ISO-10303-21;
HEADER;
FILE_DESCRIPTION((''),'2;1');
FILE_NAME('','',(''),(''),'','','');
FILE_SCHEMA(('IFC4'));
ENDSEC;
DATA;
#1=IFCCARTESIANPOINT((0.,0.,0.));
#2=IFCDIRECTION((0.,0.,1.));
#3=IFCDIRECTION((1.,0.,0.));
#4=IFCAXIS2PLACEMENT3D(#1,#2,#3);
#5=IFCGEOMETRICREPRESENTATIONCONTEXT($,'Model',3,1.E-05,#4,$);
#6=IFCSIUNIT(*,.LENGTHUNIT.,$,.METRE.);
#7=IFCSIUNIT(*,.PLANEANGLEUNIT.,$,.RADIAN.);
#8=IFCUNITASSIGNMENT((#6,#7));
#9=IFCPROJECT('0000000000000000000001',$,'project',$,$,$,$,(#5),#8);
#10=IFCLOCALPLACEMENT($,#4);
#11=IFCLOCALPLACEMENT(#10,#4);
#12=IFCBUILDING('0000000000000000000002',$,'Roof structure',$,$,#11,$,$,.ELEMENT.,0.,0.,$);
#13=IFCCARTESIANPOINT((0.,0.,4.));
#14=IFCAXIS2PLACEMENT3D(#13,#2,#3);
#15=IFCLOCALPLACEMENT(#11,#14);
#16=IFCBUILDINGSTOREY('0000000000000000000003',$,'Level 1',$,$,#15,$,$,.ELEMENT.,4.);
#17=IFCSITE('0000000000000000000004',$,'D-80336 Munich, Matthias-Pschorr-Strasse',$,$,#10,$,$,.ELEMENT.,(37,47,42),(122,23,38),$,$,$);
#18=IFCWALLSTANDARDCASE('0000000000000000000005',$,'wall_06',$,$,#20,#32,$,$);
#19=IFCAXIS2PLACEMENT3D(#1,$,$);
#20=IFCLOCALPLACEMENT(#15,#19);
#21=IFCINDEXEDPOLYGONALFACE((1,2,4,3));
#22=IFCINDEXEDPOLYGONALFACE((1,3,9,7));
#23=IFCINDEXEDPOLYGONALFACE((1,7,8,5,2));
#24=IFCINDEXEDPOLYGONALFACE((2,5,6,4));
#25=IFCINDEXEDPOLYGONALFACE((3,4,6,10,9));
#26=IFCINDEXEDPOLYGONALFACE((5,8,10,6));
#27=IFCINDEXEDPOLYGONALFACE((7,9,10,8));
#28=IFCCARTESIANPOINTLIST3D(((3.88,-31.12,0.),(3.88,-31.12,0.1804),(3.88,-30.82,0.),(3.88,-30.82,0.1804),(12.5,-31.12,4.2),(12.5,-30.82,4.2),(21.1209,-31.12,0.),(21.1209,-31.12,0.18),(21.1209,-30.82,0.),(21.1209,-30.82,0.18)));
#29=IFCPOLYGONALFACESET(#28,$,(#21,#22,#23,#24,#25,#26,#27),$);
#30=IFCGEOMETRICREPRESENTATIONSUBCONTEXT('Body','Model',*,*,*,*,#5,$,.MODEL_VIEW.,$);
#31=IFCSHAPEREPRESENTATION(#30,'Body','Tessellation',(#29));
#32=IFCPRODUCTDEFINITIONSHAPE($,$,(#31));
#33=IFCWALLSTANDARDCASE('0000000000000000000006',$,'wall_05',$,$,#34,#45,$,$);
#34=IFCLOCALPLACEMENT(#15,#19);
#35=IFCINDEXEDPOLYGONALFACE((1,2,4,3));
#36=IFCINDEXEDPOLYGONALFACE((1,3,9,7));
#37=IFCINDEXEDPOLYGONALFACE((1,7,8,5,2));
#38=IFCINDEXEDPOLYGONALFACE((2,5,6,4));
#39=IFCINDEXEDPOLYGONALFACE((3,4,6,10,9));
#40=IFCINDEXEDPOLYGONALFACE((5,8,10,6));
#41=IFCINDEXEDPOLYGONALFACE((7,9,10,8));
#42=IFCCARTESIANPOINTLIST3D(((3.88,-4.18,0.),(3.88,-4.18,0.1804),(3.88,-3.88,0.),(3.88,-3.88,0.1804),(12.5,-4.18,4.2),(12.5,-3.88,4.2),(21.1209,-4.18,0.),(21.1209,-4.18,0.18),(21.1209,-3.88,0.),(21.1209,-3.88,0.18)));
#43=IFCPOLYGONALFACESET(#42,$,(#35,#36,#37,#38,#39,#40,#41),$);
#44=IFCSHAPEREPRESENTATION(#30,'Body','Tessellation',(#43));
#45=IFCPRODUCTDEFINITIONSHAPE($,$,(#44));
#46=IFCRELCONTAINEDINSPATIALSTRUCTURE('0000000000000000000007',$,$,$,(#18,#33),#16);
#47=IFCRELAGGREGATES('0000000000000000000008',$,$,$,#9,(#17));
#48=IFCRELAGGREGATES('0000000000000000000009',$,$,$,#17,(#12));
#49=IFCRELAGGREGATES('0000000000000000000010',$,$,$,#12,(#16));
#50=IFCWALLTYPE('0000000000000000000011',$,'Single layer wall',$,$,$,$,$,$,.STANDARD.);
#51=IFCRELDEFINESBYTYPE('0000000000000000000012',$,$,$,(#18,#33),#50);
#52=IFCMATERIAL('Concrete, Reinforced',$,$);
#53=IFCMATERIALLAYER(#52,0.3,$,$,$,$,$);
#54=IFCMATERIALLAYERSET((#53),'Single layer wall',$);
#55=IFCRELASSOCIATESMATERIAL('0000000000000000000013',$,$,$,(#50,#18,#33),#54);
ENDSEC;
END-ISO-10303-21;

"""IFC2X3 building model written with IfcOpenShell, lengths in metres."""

from ifc_helpers import new_model, si_unit, frame, origin_with_axes, place, context, subcontext, project, spatial, polyline, outline, extrude, clip, bounded_halfspace, material, layer, layer_set, layer_usage, type_object, element, save


model = new_model("IFC2X3")

# Units and contexts
model_context = context("Model", 3, precision=1e-05, world=origin_with_axes())
body_context = subcontext(model_context, "Body", "Model", "MODEL_VIEW")
ifc_project = project(units=[si_unit("LENGTHUNIT", "METRE"), si_unit("PLANEANGLEUNIT", "RADIAN")], contexts=[model_context])

# Site, building, storey
site_placement = place(None, origin_with_axes())
site = spatial("IfcSite", under=ifc_project, at=site_placement, Name="D-80336 Munich, Matthias-Pschorr-Strasse", CompositionType="ELEMENT", RefLatitude=(37, 47, 42), RefLongitude=(122, 23, 38))
building_placement = place(site_placement, origin_with_axes())
building = spatial("IfcBuilding", under=site, at=building_placement, Name="Roof structure", CompositionType="ELEMENT", ElevationOfRefHeight=0.0, ElevationOfTerrain=0.0)
storey_placement = place(building_placement, frame((0.0, 0.0, 4.0), z_axis=(0.0, 0.0, 1.0), x_axis=(1.0, 0.0, 0.0)))
storey = spatial("IfcBuildingStorey", under=building, at=storey_placement, Name="Level 1", CompositionType="ELEMENT", Elevation=4.0)

# Walls
ifc_material = material(Name="Concrete, Reinforced")
ifc_layer = layer(ifc_material, 0.3)
ifc_layer_set = layer_set([ifc_layer], Name="Single layer wall")
ifc_layer_usage_1 = layer_usage(ifc_layer_set, "AXIS2", "POSITIVE", 0.0)
wall_type = type_object("IfcWallType", Name="Single layer wall", PredefinedType="STANDARD", material=ifc_layer_set)
wall_1_placement = place(storey_placement, frame((3.88, -31.12, 0.0), z_axis=(0.0, 0.0, 1.0), x_axis=(1.0, 0.0, 0.0)))
element("IfcWallStandardCase", 1, at=wall_1_placement, inside=storey, type_object=wall_type, material=ifc_layer_usage_1, Name="wall_06", context=body_context, shape_type="Clipping", body=[
    clip(clip(extrude(outline(polyline([(-8.6205, 0.15), (8.6205, 0.15), (8.6205, -0.15), (-8.6205, -0.15), (-8.6205, 0.15)])), frame((8.6205, 0.15, 0.0), z_axis=(0.0, 0.0, 1.0), x_axis=(1.0, 0.0, 0.0)), (0.0, 0.0, 1.0), 4.2), bounded_halfspace(frame((-4.7882, 31.12, -2.0523), z_axis=(-0.422618, 0.0, 0.906308), x_axis=(0.0, -1.0, 0.0)), False, frame((8.6205, 0.15, 0.0), z_axis=(0.0, 0.0, 1.0), x_axis=(1.0, 0.0, 0.0)), polyline([(-0.0005, 0.15), (-8.6205, 0.15), (-8.6205, -0.15), (-0.0005, -0.15), (-0.0005, 0.15)]))), bounded_halfspace(frame((1.4934, 31.12, 7.5232), z_axis=(0.422618, 0.0, 0.906308), x_axis=(0.0, 1.0, 0.0)), False, frame((8.6205, 0.15, 0.0), z_axis=(0.0, 0.0, 1.0), x_axis=(1.0, 0.0, 0.0)), polyline([(8.6205, 0.15), (-0.0005, 0.15), (-0.0005, -0.15), (8.6205, -0.15), (8.6205, 0.15)]))),
])
ifc_layer_usage_2 = layer_usage(ifc_layer_set, "AXIS2", "POSITIVE", 0.0)
wall_2_placement = place(storey_placement, frame((3.88, -4.18, 0.0), z_axis=(0.0, 0.0, 1.0), x_axis=(1.0, 0.0, 0.0)))
element("IfcWallStandardCase", 2, at=wall_2_placement, inside=storey, type_object=wall_type, material=ifc_layer_usage_2, Name="wall_05", context=body_context, shape_type="Clipping", body=[
    clip(clip(extrude(outline(polyline([(-8.6205, 0.15), (8.6205, 0.15), (8.6205, -0.15), (-8.6205, -0.15), (-8.6205, 0.15)])), frame((8.6205, 0.15, 0.0), z_axis=(0.0, 0.0, 1.0), x_axis=(1.0, 0.0, 0.0)), (0.0, 0.0, 1.0), 4.2), bounded_halfspace(frame((-4.7882, 4.18, -2.0523), z_axis=(-0.422618, 0.0, 0.906308), x_axis=(0.0, -1.0, 0.0)), False, frame((8.6205, 0.15, 0.0), z_axis=(0.0, 0.0, 1.0), x_axis=(1.0, 0.0, 0.0)), polyline([(-0.0005, 0.15), (-8.6205, 0.15), (-8.6205, -0.15), (-0.0005, -0.15), (-0.0005, 0.15)]))), bounded_halfspace(frame((1.4934, 4.18, 7.5232), z_axis=(0.422618, 0.0, 0.906308), x_axis=(0.0, 1.0, 0.0)), False, frame((8.6205, 0.15, 0.0), z_axis=(0.0, 0.0, 1.0), x_axis=(1.0, 0.0, 0.0)), polyline([(8.6205, 0.15), (-0.0005, 0.15), (-0.0005, -0.15), (8.6205, -0.15), (8.6205, 0.15)]))),
])

save(model, "model.ifc")
